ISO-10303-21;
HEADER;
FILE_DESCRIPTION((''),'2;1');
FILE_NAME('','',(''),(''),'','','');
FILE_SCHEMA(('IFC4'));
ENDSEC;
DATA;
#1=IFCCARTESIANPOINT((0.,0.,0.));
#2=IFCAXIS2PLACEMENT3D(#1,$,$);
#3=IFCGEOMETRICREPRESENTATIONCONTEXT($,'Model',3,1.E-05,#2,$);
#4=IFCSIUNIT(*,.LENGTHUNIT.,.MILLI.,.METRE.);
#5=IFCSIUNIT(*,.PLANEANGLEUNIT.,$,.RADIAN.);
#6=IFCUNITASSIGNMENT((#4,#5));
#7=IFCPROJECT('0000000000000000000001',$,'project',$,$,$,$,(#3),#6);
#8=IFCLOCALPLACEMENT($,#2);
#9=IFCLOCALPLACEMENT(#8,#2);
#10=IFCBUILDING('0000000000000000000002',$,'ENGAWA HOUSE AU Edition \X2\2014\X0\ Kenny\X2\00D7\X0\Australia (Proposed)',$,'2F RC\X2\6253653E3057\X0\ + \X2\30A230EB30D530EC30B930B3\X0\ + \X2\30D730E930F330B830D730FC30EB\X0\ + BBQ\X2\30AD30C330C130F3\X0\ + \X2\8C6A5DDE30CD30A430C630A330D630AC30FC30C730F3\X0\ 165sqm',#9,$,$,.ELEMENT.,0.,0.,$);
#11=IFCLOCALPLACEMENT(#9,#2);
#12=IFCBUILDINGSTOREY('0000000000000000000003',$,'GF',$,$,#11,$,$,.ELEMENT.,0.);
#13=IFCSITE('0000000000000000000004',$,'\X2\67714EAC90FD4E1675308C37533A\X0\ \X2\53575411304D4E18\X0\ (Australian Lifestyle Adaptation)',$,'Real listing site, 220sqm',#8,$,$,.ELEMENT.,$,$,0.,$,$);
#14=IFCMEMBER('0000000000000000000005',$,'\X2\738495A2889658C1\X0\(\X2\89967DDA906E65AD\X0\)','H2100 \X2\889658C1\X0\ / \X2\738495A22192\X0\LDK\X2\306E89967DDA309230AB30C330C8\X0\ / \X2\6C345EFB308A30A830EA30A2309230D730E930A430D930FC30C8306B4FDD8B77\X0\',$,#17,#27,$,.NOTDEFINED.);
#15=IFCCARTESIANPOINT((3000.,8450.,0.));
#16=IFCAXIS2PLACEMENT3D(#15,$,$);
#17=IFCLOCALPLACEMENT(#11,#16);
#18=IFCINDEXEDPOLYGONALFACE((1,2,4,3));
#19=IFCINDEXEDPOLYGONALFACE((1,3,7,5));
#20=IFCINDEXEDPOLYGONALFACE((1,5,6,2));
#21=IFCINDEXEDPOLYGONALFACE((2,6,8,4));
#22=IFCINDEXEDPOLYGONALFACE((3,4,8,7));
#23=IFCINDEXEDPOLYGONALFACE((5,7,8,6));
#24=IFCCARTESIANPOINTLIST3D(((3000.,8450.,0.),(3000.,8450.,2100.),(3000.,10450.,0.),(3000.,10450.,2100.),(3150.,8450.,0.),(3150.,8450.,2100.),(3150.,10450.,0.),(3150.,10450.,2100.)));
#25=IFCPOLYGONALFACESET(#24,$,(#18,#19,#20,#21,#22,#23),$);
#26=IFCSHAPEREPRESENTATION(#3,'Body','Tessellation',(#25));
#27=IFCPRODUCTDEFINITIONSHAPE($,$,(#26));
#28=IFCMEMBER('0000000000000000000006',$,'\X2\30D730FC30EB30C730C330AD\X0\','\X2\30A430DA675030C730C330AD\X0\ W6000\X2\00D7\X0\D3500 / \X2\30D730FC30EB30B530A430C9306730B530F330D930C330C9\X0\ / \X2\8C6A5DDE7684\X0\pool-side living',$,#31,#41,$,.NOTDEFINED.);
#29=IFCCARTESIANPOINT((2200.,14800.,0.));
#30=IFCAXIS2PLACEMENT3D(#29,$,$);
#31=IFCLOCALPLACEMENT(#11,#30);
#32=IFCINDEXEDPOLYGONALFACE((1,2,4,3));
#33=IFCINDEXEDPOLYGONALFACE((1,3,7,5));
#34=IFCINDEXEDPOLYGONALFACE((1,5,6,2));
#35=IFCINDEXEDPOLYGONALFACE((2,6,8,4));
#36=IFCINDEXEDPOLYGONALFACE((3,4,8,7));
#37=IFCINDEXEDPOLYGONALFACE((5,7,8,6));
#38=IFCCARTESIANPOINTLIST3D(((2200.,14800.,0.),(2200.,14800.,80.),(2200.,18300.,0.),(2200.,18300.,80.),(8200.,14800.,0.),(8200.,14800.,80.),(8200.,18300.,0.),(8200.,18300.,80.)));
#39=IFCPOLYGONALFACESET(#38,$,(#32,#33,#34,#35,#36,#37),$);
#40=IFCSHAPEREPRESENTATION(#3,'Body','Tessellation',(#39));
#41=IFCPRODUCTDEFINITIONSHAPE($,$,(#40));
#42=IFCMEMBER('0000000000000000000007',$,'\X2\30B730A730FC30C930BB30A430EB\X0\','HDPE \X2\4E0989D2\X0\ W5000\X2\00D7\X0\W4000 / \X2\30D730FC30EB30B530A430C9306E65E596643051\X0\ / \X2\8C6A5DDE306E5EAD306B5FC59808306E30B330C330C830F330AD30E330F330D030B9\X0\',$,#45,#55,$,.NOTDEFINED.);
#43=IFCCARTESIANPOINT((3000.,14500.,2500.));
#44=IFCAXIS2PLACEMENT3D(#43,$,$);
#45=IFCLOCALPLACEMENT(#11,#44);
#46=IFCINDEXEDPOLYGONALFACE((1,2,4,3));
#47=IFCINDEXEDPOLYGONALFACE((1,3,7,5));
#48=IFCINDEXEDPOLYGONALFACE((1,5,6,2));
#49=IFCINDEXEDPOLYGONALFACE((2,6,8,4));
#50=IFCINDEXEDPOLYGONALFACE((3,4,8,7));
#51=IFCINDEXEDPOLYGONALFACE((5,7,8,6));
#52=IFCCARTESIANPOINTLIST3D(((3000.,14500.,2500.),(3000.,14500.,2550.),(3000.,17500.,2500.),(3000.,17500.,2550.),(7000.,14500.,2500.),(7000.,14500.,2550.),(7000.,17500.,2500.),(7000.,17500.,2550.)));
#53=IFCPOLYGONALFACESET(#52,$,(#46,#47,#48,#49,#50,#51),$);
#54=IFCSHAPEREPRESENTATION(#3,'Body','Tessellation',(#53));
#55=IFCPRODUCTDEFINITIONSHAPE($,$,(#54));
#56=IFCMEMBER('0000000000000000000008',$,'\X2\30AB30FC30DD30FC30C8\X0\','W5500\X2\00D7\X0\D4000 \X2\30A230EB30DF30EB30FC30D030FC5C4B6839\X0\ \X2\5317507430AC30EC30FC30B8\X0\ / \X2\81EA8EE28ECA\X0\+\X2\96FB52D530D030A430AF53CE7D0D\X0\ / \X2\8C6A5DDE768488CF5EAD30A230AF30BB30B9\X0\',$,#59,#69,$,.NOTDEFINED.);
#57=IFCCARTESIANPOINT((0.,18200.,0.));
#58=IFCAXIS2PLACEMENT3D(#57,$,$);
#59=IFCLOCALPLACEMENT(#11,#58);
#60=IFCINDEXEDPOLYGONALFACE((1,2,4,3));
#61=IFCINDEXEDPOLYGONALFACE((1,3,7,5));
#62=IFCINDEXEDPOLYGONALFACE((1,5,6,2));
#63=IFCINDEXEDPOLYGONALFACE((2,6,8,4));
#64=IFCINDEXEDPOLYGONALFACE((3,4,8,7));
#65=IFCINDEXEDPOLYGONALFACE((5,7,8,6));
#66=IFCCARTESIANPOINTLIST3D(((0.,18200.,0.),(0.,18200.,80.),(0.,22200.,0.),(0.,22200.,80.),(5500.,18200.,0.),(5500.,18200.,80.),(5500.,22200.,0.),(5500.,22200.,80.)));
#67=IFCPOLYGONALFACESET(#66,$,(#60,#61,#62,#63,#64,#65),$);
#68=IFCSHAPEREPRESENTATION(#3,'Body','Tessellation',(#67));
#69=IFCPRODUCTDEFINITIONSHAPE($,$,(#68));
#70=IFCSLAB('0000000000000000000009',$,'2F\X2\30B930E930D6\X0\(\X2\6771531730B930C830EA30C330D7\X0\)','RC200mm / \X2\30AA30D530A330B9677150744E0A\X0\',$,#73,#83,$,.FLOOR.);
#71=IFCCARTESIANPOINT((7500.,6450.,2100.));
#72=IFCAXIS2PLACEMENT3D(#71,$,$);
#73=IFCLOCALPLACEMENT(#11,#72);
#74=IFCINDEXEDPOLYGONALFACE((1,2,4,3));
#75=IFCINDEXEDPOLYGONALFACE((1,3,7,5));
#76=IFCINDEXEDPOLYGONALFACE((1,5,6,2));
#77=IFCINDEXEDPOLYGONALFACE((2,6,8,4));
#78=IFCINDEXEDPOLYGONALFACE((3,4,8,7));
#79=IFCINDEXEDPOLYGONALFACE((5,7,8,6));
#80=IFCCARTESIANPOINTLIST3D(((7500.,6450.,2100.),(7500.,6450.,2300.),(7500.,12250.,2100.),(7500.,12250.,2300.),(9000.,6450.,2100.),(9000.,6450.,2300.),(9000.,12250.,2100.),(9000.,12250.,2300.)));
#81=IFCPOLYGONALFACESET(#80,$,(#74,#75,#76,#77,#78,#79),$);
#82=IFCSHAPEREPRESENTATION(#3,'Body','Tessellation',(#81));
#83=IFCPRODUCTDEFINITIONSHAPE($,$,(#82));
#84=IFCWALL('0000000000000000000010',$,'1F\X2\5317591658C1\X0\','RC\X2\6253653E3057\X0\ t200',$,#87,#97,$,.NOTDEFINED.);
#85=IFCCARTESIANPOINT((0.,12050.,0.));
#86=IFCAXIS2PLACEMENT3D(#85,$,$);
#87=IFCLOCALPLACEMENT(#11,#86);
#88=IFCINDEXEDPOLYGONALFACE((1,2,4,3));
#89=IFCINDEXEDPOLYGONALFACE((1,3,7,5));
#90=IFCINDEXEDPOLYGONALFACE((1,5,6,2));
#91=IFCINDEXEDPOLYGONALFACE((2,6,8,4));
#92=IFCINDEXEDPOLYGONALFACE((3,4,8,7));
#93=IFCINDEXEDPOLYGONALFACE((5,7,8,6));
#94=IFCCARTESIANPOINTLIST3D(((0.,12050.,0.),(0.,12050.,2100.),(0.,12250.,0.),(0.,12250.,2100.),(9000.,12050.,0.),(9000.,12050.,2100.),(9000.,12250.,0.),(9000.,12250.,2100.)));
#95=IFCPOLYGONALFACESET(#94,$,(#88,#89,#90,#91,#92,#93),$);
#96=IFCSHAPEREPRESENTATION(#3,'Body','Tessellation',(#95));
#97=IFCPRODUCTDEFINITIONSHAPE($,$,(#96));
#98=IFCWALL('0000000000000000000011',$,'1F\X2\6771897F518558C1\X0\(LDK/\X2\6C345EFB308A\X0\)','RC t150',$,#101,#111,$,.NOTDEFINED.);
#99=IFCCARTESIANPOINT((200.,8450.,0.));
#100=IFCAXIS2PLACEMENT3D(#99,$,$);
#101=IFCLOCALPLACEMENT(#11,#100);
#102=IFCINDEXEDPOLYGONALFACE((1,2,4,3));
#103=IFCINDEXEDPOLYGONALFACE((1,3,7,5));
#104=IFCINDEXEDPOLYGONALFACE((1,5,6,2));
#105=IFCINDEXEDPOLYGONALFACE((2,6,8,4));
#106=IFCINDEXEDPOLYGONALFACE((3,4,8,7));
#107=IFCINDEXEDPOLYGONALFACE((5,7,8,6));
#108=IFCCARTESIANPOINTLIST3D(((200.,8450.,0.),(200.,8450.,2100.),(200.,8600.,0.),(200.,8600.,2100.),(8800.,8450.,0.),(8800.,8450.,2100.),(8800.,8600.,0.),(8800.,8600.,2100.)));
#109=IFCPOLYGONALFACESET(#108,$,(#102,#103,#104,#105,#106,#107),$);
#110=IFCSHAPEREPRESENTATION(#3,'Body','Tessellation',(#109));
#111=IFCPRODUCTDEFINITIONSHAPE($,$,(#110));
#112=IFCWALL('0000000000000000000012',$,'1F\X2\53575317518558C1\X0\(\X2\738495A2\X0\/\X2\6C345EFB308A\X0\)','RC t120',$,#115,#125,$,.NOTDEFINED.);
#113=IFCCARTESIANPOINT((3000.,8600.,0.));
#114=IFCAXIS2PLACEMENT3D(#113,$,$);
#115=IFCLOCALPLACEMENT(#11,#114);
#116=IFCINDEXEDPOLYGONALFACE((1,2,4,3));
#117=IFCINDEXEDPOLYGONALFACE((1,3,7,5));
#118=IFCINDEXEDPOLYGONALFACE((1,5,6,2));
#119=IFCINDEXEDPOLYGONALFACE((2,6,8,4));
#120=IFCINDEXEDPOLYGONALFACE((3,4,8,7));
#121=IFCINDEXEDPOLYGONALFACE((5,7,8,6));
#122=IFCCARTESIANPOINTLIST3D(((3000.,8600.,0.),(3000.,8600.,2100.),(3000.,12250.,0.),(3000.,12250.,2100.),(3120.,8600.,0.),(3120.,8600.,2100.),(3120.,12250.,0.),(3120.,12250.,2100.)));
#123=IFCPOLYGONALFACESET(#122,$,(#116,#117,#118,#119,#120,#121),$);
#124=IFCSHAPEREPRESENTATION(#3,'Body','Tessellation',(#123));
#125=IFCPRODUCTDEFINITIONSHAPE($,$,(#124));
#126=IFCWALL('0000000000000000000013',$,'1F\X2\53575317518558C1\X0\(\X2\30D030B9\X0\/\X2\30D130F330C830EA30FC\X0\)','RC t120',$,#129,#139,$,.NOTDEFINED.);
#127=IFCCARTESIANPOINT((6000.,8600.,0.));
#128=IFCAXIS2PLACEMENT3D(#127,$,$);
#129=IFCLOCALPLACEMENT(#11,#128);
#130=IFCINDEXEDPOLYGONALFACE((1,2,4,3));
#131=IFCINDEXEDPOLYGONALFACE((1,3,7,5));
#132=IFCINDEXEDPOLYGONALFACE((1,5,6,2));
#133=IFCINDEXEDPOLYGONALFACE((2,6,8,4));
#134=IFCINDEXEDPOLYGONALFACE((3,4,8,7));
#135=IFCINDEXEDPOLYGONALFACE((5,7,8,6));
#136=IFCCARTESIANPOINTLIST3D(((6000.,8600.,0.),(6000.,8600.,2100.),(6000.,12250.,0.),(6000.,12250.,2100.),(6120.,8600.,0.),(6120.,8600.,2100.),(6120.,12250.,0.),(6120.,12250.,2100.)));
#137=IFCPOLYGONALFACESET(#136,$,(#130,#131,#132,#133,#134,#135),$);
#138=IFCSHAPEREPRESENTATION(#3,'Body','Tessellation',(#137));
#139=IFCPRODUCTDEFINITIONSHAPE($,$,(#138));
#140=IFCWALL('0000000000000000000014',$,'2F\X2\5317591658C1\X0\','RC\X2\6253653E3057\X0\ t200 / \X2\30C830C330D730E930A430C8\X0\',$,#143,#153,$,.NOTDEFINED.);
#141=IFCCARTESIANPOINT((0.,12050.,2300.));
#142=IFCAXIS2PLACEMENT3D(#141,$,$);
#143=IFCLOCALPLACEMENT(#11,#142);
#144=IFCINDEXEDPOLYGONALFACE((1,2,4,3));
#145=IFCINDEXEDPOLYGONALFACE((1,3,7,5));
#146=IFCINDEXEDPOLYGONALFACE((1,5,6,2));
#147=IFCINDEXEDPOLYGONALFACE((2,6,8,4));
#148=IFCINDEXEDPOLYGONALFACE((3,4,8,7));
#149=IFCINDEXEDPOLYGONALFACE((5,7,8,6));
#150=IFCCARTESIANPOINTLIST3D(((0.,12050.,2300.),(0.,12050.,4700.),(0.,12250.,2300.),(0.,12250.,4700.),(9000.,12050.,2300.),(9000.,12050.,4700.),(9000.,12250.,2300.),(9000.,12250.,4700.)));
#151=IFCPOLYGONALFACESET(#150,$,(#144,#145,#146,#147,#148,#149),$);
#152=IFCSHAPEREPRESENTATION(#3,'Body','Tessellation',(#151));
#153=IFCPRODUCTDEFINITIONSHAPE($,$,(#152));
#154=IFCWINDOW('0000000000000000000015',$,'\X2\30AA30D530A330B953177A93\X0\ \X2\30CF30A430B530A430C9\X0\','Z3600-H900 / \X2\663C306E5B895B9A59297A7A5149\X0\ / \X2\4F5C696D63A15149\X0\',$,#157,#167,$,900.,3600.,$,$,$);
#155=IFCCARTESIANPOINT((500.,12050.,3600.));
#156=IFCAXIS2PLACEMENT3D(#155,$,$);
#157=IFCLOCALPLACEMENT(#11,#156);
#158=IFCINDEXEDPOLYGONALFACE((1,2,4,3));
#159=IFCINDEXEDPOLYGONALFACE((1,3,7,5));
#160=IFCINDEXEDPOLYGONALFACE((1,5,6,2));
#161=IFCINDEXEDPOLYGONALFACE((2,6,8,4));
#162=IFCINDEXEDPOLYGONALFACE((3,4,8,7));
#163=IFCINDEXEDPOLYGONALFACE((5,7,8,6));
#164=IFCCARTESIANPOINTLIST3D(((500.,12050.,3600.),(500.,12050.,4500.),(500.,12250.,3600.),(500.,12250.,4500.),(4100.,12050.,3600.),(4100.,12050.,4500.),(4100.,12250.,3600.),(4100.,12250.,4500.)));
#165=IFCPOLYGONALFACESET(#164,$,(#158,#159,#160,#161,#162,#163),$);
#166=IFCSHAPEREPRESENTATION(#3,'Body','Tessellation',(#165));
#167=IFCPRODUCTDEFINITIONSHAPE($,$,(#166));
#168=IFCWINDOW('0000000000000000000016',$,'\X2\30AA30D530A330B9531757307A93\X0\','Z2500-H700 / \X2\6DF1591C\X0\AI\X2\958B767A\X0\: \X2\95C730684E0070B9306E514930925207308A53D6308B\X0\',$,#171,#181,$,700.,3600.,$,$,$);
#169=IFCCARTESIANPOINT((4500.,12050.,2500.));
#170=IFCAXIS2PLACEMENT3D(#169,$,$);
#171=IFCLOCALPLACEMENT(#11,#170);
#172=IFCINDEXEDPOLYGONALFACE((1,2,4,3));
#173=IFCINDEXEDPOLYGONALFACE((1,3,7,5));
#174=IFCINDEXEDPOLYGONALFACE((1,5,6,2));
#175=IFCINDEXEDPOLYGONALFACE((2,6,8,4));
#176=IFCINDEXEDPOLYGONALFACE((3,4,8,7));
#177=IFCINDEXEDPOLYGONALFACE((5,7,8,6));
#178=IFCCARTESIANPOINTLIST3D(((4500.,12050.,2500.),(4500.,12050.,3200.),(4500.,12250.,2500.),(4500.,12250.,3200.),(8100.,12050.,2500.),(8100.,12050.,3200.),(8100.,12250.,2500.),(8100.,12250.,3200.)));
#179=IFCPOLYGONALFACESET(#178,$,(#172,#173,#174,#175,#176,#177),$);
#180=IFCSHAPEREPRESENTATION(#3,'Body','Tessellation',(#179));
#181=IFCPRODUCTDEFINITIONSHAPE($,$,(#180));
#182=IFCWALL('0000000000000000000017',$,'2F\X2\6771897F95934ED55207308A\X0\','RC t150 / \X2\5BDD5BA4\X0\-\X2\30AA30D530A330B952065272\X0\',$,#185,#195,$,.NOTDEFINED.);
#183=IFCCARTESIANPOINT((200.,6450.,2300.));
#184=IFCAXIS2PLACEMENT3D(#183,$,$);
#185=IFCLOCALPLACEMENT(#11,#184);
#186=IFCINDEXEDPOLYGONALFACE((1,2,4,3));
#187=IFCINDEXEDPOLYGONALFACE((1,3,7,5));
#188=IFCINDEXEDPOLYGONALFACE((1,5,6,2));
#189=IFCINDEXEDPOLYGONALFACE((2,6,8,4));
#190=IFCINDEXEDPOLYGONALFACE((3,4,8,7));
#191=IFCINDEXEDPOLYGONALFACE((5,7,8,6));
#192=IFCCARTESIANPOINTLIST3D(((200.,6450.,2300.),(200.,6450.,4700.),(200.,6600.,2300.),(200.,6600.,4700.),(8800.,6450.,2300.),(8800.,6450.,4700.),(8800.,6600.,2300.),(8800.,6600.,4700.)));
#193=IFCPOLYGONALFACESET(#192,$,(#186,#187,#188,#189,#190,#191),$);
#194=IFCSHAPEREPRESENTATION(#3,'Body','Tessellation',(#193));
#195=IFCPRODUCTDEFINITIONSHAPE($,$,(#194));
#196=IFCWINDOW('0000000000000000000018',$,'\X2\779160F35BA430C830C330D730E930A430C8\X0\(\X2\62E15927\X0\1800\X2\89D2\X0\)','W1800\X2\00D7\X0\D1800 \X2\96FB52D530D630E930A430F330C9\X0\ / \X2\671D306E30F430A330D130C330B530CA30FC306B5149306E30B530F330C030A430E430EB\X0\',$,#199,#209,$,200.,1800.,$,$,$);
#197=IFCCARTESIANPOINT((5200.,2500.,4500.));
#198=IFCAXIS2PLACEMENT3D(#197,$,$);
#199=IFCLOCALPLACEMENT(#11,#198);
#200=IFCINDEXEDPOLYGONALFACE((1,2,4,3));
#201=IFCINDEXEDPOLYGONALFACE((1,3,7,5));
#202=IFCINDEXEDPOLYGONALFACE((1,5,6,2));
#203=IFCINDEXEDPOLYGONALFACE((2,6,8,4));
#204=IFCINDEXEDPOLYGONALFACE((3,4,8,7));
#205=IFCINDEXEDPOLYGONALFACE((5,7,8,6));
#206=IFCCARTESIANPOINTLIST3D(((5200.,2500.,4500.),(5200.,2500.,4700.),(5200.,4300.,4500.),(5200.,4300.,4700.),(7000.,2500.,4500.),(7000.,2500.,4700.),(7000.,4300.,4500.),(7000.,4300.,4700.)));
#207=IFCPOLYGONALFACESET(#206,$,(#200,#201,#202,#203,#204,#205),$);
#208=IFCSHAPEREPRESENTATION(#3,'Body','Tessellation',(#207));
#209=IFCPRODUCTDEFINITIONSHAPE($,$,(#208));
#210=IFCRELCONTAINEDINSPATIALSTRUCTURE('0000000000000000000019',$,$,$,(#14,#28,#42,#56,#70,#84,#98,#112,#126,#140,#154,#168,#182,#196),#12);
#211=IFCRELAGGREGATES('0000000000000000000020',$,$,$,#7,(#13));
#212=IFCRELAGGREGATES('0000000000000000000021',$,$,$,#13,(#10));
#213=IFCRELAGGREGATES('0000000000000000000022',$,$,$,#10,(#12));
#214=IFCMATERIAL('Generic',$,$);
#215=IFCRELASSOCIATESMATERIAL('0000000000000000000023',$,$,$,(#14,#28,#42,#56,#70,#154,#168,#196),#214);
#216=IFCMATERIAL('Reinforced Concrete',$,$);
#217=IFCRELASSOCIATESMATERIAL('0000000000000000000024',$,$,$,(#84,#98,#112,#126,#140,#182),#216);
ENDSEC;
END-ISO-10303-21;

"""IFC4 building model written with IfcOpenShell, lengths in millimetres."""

from ifc_helpers import new_model, si_unit, frame, frame_2d, origin, place, context, project, spatial, rectangle, extrude, material, element, fill, save


model = new_model("IFC4")

# Units and contexts
model_context = context("Model", 3, precision=1e-05, world=origin())
ifc_project = project(units=[si_unit("LENGTHUNIT", "METRE", prefix="MILLI"), si_unit("PLANEANGLEUNIT", "RADIAN")], contexts=[model_context])

# Site, building, storey
site_placement = place(None, origin())
site = spatial("IfcSite", under=ifc_project, at=site_placement, Name="東京都世田谷区 南向き丘 (Australian Lifestyle Adaptation)", ObjectType="Real listing site, 220sqm", CompositionType="ELEMENT", RefElevation=0.0)
building_placement = place(site_placement, origin())
building = spatial("IfcBuilding", under=site, at=building_placement, Name="ENGAWA HOUSE AU Edition — Kenny×Australia (Proposed)", ObjectType="2F RC打放し + アルフレスコ + プランジプール + BBQキッチン + 豪州ネイティブガーデン 165sqm", CompositionType="ELEMENT", ElevationOfRefHeight=0.0, ElevationOfTerrain=0.0)
storey_placement = place(building_placement, origin())
storey = spatial("IfcBuildingStorey", under=building, at=storey_placement, Name="GF", CompositionType="ELEMENT", Elevation=0.0)

# Members
ifc_material_1 = material(Name="Generic")
member_1_placement = place(storey_placement, frame((3000.0, 8450.0, 0.0)))
element("IfcMember", 1, at=member_1_placement, inside=storey, material=ifc_material_1, Name="玄関袖壁(視線遮断)", Description="H2100 袖壁 / 玄関→LDKの視線をカット / 水廻りエリアをプライベートに保護", PredefinedType="NOTDEFINED", context=model_context, shape_type="SweptSolid", body=[
    extrude(rectangle(XDim=150.0, YDim=2000.0, at=frame_2d((75.0, 1000.0))), frame((3000.0, 8450.0, 0.0)), (0.0, 0.0, 1.0), 2100.0),
])
member_2_placement = place(storey_placement, frame((2200.0, 14800.0, 0.0)))
element("IfcMember", 2, at=member_2_placement, inside=storey, material=ifc_material_1, Name="プールデッキ", Description="イペ材デッキ W6000×D3500 / プールサイドでサンベッド / 豪州的pool-side living", PredefinedType="NOTDEFINED", context=model_context, shape_type="SweptSolid", body=[
    extrude(rectangle(XDim=6000.0, YDim=3500.0, at=frame_2d((3000.0, 1750.0))), frame((2200.0, 14800.0, 0.0)), (0.0, 0.0, 1.0), 80.0),
])
member_3_placement = place(storey_placement, frame((3000.0, 14500.0, 2500.0)))
element("IfcMember", 3, at=member_3_placement, inside=storey, material=ifc_material_1, Name="シェードセイル", Description="HDPE 三角 W5000×W4000 / プールサイドの日除け / 豪州の庭に必須のコットンキャンバス", PredefinedType="NOTDEFINED", context=model_context, shape_type="SweptSolid", body=[
    extrude(rectangle(XDim=4000.0, YDim=3000.0, at=frame_2d((2000.0, 1500.0))), frame((3000.0, 14500.0, 2500.0)), (0.0, 0.0, 1.0), 50.0),
])
member_4_placement = place(storey_placement, frame((0.0, 18200.0, 0.0)))
element("IfcMember", 4, at=member_4_placement, inside=storey, material=ifc_material_1, Name="カーポート", Description="W5500×D4000 アルミルーバー屋根 北側ガレージ / 自転車+電動バイク収納 / 豪州的裏庭アクセス", PredefinedType="NOTDEFINED", context=model_context, shape_type="SweptSolid", body=[
    extrude(rectangle(XDim=5500.0, YDim=4000.0, at=frame_2d((2750.0, 2000.0))), frame((0.0, 18200.0, 0.0)), (0.0, 0.0, 1.0), 80.0),
])

# Slab
slab_1_placement = place(storey_placement, frame((7500.0, 6450.0, 2100.0)))
element("IfcSlab", 5, at=slab_1_placement, inside=storey, material=ifc_material_1, Name="2Fスラブ(東北ストリップ)", Description="RC200mm / オフィス東側上", PredefinedType="FLOOR", context=model_context, shape_type="SweptSolid", body=[
    extrude(rectangle(XDim=1500.0, YDim=5800.0, at=frame_2d((750.0, 2900.0))), frame((7500.0, 6450.0, 2100.0)), (0.0, 0.0, 1.0), 200.0),
])

# Walls
ifc_material_2 = material(Name="Reinforced Concrete")
wall_1_placement = place(storey_placement, frame((0.0, 12050.0, 0.0)))
element("IfcWall", 6, at=wall_1_placement, inside=storey, material=ifc_material_2, Name="1F北外壁", Description="RC打放し t200", PredefinedType="NOTDEFINED", context=model_context, shape_type="SweptSolid", body=[
    extrude(rectangle(XDim=9000.0, YDim=200.0, at=frame_2d((4500.0, 100.0))), frame((0.0, 12050.0, 0.0)), (0.0, 0.0, 1.0), 2100.0),
])
wall_2_placement = place(storey_placement, frame((200.0, 8450.0, 0.0)))
element("IfcWall", 7, at=wall_2_placement, inside=storey, material=ifc_material_2, Name="1F東西内壁(LDK/水廻り)", Description="RC t150", PredefinedType="NOTDEFINED", context=model_context, shape_type="SweptSolid", body=[
    extrude(rectangle(XDim=8600.0, YDim=150.0, at=frame_2d((4300.0, 75.0))), frame((200.0, 8450.0, 0.0)), (0.0, 0.0, 1.0), 2100.0),
])
wall_3_placement = place(storey_placement, frame((3000.0, 8600.0, 0.0)))
element("IfcWall", 8, at=wall_3_placement, inside=storey, material=ifc_material_2, Name="1F南北内壁(玄関/水廻り)", Description="RC t120", PredefinedType="NOTDEFINED", context=model_context, shape_type="SweptSolid", body=[
    extrude(rectangle(XDim=120.0, YDim=3650.0, at=frame_2d((60.0, 1825.0))), frame((3000.0, 8600.0, 0.0)), (0.0, 0.0, 1.0), 2100.0),
])
wall_4_placement = place(storey_placement, frame((6000.0, 8600.0, 0.0)))
element("IfcWall", 9, at=wall_4_placement, inside=storey, material=ifc_material_2, Name="1F南北内壁(バス/パントリー)", Description="RC t120", PredefinedType="NOTDEFINED", context=model_context, shape_type="SweptSolid", body=[
    extrude(rectangle(XDim=120.0, YDim=3650.0, at=frame_2d((60.0, 1825.0))), frame((6000.0, 8600.0, 0.0)), (0.0, 0.0, 1.0), 2100.0),
])

# Wall, openings, windows
wall_5_placement = place(storey_placement, frame((0.0, 12050.0, 2300.0)))
wall_5 = element("IfcWall", 10, at=wall_5_placement, inside=storey, material=ifc_material_2, Name="2F北外壁", Description="RC打放し t200 / トップライト", PredefinedType="NOTDEFINED", context=model_context, shape_type="SweptSolid", body=[
    extrude(rectangle(XDim=9000.0, YDim=200.0, at=frame_2d((4500.0, 100.0))), frame((0.0, 12050.0, 2300.0)), (0.0, 0.0, 1.0), 2400.0),
])
opening_1_placement = place(storey_placement, frame((500.0, 12050.0, 3600.0)))
opening_1 = element("IfcOpeningElement", 11, at=opening_1_placement, cuts=wall_5, PredefinedType="NOTDEFINED", context=model_context, shape_type="SweptSolid", body=[
    extrude(rectangle(XDim=3600.0, YDim=200.0, at=frame_2d((1800.0, 100.0))), frame((500.0, 12050.0, 3600.0)), (0.0, 0.0, 1.0), 900.0),
])
opening_2_placement = place(storey_placement, frame((4500.0, 12050.0, 2500.0)))
opening_2 = element("IfcOpeningElement", 12, at=opening_2_placement, cuts=wall_5, PredefinedType="NOTDEFINED", context=model_context, shape_type="SweptSolid", body=[
    extrude(rectangle(XDim=3600.0, YDim=200.0, at=frame_2d((1800.0, 100.0))), frame((4500.0, 12050.0, 2500.0)), (0.0, 0.0, 1.0), 700.0),
])
window_1_placement = place(storey_placement, frame((500.0, 12050.0, 3600.0)))
window_1 = element("IfcWindow", 13, at=window_1_placement, inside=storey, material=ifc_material_1, Name="オフィス北窓 ハイサイド", Description="Z3600-H900 / 昼の安定天空光 / 作業採光", OverallHeight=900.0, OverallWidth=3600.0, context=model_context, shape_type="SweptSolid", body=[
    extrude(rectangle(XDim=3600.0, YDim=200.0, at=frame_2d((1800.0, 100.0))), frame((500.0, 12050.0, 3600.0)), (0.0, 0.0, 1.0), 900.0),
])
fill(opening_1, window_1)
window_2_placement = place(storey_placement, frame((4500.0, 12050.0, 2500.0)))
window_2 = element("IfcWindow", 14, at=window_2_placement, inside=storey, material=ifc_material_1, Name="オフィス北地窓", Description="Z2500-H700 / 深夜AI開発: 闇と一点の光を切り取る", OverallHeight=700.0, OverallWidth=3600.0, context=model_context, shape_type="SweptSolid", body=[
    extrude(rectangle(XDim=3600.0, YDim=200.0, at=frame_2d((1800.0, 100.0))), frame((4500.0, 12050.0, 2500.0)), (0.0, 0.0, 1.0), 700.0),
])
fill(opening_2, window_2)

# Wall
wall_6_placement = place(storey_placement, frame((200.0, 6450.0, 2300.0)))
element("IfcWall", 15, at=wall_6_placement, inside=storey, material=ifc_material_2, Name="2F東西間仕切り", Description="RC t150 / 寝室-オフィス分割", PredefinedType="NOTDEFINED", context=model_context, shape_type="SweptSolid", body=[
    extrude(rectangle(XDim=8600.0, YDim=150.0, at=frame_2d((4300.0, 75.0))), frame((200.0, 6450.0, 2300.0)), (0.0, 0.0, 1.0), 2400.0),
])

# Window
window_3_placement = place(storey_placement, frame((5200.0, 2500.0, 4500.0)))
element("IfcWindow", 16, at=window_3_placement, inside=storey, material=ifc_material_1, Name="瞑想室トップライト(拡大1800角)", Description="W1800×D1800 電動ブラインド / 朝のヴィパッサナーに光のサンダイヤル", OverallHeight=200.0, OverallWidth=1800.0, context=model_context, shape_type="SweptSolid", body=[
    extrude(rectangle(XDim=1800.0, YDim=1800.0, at=frame_2d((900.0, 900.0))), frame((5200.0, 2500.0, 4500.0)), (0.0, 0.0, 1.0), 200.0),
])

save(model, "model.ifc")
